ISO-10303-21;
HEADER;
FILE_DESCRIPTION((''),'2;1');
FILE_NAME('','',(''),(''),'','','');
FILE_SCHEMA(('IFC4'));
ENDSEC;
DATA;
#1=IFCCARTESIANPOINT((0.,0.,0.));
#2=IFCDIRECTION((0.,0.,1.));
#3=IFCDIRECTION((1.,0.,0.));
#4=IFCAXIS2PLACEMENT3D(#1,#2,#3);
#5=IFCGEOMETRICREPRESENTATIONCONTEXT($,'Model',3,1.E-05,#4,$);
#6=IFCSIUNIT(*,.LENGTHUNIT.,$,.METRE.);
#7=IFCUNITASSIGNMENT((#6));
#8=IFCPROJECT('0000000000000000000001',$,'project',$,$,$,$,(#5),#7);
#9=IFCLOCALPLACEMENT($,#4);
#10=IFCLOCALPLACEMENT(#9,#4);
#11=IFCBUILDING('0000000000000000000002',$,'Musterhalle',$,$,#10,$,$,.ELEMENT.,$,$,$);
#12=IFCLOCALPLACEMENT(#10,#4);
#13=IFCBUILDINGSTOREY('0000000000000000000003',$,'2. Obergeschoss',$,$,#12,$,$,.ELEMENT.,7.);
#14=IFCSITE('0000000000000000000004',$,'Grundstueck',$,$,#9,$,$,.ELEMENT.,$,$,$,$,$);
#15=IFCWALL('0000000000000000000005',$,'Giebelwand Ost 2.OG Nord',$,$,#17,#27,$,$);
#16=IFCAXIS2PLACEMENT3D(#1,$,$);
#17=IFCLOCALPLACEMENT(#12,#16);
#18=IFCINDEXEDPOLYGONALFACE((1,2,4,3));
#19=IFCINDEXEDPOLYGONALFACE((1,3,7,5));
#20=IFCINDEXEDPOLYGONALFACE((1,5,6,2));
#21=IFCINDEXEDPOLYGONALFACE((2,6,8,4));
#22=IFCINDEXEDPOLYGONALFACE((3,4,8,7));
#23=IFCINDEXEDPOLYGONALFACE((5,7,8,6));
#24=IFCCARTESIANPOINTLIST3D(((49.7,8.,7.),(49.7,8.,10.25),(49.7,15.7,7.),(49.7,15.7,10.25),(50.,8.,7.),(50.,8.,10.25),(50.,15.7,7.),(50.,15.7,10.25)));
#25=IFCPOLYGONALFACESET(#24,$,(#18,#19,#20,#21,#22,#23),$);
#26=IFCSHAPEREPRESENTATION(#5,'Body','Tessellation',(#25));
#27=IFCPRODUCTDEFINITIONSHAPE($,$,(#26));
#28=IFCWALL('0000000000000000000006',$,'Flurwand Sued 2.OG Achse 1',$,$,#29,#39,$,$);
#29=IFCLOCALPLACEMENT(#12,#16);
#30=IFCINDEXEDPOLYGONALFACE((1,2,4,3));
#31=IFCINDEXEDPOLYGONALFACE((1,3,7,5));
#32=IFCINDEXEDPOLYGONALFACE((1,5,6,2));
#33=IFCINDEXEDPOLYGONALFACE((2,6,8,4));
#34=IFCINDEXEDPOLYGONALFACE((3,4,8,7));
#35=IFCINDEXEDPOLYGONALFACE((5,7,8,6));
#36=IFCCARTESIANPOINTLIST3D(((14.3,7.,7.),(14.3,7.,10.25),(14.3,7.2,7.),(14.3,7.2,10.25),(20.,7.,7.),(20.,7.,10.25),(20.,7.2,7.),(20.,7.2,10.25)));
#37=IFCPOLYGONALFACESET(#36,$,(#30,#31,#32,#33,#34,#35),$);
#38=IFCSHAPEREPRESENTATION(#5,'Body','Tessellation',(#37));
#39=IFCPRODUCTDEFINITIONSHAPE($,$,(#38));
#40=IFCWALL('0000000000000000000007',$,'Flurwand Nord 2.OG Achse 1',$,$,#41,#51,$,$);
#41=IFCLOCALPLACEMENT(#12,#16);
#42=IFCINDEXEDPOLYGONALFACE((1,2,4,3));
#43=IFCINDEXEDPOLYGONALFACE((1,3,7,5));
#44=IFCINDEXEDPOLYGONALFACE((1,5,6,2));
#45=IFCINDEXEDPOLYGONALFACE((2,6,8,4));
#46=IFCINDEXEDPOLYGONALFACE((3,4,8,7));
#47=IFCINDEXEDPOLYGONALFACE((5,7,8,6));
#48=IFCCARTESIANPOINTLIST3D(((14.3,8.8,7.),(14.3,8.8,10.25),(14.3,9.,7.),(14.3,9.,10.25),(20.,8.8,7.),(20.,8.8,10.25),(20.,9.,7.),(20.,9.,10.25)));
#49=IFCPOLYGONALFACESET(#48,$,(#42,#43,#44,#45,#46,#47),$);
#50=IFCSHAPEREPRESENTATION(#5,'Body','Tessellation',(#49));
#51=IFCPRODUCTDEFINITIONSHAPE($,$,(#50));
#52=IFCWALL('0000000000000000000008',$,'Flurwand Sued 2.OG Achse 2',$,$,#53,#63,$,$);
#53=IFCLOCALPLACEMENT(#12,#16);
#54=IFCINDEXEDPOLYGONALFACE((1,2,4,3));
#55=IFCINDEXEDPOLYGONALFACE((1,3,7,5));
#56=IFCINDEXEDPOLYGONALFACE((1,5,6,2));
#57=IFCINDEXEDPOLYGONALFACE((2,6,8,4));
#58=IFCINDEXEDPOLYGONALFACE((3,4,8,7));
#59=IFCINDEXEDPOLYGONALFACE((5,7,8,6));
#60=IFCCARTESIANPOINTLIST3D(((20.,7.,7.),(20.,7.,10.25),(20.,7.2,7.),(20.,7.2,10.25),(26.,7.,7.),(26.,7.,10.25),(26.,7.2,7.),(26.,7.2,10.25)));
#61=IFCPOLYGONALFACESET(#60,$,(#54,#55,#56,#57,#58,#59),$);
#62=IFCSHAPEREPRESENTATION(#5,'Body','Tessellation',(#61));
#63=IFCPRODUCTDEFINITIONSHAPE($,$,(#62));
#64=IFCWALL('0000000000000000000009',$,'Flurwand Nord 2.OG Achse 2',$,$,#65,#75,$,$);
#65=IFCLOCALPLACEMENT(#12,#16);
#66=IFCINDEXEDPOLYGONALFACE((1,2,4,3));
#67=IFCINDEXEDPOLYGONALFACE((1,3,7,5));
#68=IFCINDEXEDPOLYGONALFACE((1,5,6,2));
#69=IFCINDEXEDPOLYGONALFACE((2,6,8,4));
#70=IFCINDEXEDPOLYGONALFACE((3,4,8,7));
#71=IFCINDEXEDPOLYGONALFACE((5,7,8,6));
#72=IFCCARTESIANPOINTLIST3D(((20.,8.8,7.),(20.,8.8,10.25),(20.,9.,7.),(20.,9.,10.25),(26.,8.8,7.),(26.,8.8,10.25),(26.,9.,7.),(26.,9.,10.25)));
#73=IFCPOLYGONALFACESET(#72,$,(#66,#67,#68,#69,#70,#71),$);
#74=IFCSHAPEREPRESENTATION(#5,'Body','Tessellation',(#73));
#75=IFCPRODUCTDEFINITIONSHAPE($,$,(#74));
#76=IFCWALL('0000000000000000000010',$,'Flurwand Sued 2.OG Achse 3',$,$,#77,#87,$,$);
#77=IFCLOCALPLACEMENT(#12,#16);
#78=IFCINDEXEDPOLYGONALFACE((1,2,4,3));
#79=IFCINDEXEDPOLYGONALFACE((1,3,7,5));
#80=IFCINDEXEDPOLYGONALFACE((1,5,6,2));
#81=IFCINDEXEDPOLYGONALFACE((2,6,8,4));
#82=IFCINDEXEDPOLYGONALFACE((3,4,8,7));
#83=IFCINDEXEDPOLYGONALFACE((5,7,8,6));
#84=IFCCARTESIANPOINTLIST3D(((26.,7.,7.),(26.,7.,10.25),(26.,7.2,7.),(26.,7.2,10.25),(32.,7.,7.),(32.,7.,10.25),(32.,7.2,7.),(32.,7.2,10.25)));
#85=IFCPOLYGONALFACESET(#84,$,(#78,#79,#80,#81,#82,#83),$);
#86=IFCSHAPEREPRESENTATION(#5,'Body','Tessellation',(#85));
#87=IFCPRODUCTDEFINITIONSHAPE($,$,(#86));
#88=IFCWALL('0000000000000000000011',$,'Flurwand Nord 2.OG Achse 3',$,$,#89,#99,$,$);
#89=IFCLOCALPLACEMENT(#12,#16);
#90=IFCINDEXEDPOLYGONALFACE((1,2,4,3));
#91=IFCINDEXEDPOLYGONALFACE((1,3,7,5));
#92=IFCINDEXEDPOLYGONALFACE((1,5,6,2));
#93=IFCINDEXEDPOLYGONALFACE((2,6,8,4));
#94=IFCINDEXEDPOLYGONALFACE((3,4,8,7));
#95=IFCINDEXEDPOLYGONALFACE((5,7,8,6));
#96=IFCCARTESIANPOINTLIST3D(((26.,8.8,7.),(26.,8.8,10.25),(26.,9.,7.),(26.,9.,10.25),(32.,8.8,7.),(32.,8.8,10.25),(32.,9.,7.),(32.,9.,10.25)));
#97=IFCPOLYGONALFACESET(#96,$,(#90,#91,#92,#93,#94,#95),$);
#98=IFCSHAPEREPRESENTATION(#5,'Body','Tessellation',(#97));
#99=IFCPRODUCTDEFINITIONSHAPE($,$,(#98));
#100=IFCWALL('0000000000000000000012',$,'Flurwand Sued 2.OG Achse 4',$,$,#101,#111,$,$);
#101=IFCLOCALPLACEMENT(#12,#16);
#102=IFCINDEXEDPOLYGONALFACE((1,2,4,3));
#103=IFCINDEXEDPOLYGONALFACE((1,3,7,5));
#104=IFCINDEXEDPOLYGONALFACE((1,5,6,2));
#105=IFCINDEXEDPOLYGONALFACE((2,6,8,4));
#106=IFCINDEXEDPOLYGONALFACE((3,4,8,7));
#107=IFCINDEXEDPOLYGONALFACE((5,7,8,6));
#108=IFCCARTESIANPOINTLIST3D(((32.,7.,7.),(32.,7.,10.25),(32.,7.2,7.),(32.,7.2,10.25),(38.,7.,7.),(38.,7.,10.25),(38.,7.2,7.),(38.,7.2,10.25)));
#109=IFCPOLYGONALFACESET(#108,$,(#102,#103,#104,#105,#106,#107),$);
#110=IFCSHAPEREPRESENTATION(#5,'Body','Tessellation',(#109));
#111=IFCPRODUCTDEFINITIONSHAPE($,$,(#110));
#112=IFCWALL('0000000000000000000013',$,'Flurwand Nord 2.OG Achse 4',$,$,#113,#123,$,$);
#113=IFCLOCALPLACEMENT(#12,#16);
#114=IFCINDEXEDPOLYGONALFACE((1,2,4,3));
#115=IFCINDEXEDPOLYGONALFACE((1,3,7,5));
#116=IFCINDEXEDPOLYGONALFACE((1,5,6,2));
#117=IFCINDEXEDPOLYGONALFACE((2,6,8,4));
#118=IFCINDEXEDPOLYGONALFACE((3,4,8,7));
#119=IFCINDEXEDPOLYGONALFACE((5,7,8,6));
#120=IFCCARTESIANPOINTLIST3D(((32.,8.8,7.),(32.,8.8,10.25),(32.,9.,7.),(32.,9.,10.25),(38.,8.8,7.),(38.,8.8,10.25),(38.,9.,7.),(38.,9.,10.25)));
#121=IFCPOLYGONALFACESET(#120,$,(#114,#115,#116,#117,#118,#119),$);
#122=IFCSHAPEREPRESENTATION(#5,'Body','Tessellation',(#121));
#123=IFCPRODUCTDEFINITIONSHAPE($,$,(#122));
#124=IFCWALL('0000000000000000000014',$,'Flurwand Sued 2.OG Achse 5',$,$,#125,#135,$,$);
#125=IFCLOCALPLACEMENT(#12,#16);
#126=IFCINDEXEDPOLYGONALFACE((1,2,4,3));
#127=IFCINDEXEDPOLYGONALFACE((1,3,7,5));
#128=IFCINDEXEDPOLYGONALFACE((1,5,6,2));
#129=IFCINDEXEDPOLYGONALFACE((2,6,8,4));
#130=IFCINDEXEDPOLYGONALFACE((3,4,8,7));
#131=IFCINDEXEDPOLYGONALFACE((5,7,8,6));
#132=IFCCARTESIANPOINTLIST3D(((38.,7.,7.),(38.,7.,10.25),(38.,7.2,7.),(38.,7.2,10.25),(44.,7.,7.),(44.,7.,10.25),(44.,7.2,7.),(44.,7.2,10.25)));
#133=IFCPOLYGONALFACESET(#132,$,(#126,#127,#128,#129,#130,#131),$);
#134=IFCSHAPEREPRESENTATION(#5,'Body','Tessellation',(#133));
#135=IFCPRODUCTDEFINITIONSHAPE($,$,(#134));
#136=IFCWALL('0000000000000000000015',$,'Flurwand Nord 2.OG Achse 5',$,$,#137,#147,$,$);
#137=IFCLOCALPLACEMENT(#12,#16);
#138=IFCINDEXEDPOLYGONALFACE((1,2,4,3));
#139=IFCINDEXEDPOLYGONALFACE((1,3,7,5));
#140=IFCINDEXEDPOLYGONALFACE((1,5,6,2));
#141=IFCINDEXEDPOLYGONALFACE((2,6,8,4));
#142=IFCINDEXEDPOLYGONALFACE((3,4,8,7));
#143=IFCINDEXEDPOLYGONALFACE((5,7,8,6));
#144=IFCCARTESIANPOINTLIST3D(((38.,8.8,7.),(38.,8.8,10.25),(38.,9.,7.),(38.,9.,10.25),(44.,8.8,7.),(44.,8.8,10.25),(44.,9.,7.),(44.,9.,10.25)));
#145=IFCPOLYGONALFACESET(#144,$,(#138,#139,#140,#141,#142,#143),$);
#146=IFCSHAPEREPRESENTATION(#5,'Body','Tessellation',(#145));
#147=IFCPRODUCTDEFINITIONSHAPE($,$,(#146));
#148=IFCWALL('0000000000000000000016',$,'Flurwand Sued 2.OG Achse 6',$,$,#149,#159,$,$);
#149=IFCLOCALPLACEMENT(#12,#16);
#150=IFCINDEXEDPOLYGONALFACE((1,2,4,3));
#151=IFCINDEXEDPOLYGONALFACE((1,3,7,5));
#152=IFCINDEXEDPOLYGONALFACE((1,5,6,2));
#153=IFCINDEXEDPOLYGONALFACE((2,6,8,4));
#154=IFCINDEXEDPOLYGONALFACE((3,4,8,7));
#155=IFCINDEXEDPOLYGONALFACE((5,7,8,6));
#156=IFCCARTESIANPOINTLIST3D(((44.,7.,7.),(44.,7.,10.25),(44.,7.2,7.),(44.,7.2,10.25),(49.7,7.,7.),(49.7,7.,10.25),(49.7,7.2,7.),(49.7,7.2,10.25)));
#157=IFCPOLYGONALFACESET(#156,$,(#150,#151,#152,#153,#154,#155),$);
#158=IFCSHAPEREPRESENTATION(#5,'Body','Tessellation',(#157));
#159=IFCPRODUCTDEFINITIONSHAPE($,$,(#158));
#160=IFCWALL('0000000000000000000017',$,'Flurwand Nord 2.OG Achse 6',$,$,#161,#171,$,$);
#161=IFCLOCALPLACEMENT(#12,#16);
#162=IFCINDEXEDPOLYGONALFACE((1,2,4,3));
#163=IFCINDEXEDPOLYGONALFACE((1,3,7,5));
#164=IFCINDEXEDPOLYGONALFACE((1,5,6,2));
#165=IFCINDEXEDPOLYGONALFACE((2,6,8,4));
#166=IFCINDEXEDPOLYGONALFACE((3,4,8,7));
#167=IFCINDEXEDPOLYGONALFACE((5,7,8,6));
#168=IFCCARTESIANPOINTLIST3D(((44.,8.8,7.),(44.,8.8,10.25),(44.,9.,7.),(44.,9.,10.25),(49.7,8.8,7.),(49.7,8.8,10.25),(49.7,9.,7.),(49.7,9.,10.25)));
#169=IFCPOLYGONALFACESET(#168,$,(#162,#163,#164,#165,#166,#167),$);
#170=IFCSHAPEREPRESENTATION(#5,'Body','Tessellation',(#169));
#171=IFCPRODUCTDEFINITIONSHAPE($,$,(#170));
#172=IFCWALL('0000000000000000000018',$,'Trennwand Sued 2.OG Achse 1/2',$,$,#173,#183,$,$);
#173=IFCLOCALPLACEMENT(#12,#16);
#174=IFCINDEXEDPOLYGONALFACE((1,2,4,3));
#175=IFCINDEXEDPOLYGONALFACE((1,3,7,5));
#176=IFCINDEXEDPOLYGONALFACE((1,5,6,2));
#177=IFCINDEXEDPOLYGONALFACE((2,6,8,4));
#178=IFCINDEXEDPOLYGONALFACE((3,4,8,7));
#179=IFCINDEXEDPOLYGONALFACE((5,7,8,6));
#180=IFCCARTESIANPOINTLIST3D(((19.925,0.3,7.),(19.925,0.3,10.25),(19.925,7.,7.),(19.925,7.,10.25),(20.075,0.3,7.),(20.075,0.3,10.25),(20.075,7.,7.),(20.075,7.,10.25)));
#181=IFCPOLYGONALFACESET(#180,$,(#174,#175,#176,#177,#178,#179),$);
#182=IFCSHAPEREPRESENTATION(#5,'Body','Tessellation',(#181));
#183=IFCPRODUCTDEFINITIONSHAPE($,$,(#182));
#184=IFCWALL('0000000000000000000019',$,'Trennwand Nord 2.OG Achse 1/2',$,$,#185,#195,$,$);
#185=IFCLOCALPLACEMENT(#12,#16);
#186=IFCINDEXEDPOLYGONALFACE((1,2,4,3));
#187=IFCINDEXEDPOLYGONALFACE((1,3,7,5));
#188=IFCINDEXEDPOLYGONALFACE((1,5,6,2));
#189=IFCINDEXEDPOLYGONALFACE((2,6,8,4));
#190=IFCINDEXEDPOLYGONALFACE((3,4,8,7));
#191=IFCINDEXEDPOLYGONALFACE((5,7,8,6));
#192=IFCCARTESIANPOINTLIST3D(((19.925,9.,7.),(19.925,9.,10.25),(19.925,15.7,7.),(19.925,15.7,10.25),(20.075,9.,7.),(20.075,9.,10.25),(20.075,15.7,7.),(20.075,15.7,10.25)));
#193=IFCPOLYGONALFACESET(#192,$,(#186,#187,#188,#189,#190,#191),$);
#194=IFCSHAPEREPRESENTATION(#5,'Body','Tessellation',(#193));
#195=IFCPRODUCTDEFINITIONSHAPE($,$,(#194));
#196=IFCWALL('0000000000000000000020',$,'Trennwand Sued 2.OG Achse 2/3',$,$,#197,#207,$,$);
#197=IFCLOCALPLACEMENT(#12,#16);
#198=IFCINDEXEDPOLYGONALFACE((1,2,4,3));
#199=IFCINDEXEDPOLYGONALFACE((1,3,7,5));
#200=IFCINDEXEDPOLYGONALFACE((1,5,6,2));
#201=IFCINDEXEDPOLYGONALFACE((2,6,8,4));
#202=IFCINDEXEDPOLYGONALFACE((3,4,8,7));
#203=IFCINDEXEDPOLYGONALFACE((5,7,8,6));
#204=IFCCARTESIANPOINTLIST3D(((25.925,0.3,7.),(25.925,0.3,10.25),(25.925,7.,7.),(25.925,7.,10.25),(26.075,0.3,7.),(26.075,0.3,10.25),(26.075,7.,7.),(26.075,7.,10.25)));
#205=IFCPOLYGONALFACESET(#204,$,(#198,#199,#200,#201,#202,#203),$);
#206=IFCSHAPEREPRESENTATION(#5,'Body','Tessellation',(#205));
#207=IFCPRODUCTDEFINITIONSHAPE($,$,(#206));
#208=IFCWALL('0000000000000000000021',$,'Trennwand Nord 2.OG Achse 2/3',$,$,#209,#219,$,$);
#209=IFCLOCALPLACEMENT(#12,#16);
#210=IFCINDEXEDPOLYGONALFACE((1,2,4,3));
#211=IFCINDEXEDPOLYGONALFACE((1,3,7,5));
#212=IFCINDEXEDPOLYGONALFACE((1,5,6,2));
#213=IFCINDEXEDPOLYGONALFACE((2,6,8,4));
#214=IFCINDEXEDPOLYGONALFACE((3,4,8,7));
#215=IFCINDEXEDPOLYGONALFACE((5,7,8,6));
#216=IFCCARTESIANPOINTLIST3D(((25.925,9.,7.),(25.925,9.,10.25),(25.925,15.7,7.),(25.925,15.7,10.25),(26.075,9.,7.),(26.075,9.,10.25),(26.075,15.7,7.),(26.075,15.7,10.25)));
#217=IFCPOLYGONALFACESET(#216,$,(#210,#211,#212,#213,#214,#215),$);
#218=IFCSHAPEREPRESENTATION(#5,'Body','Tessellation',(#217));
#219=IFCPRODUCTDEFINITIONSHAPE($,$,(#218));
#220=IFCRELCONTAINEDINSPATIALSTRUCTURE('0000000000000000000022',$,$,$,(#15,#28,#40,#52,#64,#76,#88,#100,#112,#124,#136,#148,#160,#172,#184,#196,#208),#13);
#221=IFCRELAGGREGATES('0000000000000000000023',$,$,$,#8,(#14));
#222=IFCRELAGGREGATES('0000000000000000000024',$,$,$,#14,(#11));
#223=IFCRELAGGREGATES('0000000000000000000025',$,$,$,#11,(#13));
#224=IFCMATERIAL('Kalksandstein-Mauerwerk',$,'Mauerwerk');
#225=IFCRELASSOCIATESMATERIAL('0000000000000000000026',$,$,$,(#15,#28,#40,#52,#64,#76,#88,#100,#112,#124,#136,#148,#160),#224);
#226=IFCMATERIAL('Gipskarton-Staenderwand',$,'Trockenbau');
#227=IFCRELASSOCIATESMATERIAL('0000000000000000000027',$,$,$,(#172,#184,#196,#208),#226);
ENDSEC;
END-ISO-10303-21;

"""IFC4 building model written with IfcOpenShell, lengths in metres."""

from ifc_helpers import new_model, si_unit, frame, origin_with_axes, origin_2d, place, context, project, spatial, rectangle, extrude, material, element, save


model = new_model("IFC4")

# Units and contexts
model_context = context("Model", 3, precision=1e-05, world=origin_with_axes())
ifc_project = project(units=[si_unit("LENGTHUNIT", "METRE")], contexts=[model_context])

# Site, building, storey
site_placement = place(None, origin_with_axes())
site = spatial("IfcSite", under=ifc_project, at=site_placement, Name="Grundstueck", CompositionType="ELEMENT")
building_placement = place(site_placement, origin_with_axes())
building = spatial("IfcBuilding", under=site, at=building_placement, Name="Musterhalle", CompositionType="ELEMENT")
storey_placement = place(building_placement, origin_with_axes())
storey = spatial("IfcBuildingStorey", under=building, at=storey_placement, Name="2. Obergeschoss", CompositionType="ELEMENT", Elevation=7.0)

# Walls
ifc_material_1 = material(Name="Kalksandstein-Mauerwerk", Category="Mauerwerk")
placement = place(storey_placement, origin_with_axes())
element("IfcWall", 1, at=placement, inside=storey, material=ifc_material_1, Name="Giebelwand Ost 2.OG Nord", context=model_context, shape_type="SweptSolid", body=[
    extrude(rectangle(XDim=0.3, YDim=7.7, at=origin_2d()), frame((49.85, 11.85, 7.0), z_axis=(0.0, 0.0, 1.0), x_axis=(1.0, 0.0, 0.0)), (0.0, 0.0, 1.0), 3.25),
])
element("IfcWall", 2, at=placement, inside=storey, material=ifc_material_1, Name="Flurwand Sued 2.OG Achse 1", context=model_context, shape_type="SweptSolid", body=[
    extrude(rectangle(XDim=5.7, YDim=0.2, at=origin_2d()), frame((17.15, 7.1, 7.0), z_axis=(0.0, 0.0, 1.0), x_axis=(1.0, 0.0, 0.0)), (0.0, 0.0, 1.0), 3.25),
])
element("IfcWall", 3, at=placement, inside=storey, material=ifc_material_1, Name="Flurwand Nord 2.OG Achse 1", context=model_context, shape_type="SweptSolid", body=[
    extrude(rectangle(XDim=5.7, YDim=0.2, at=origin_2d()), frame((17.15, 8.9, 7.0), z_axis=(0.0, 0.0, 1.0), x_axis=(1.0, 0.0, 0.0)), (0.0, 0.0, 1.0), 3.25),
])
element("IfcWall", 4, at=placement, inside=storey, material=ifc_material_1, Name="Flurwand Sued 2.OG Achse 2", context=model_context, shape_type="SweptSolid", body=[
    extrude(rectangle(XDim=6.0, YDim=0.2, at=origin_2d()), frame((23.0, 7.1, 7.0), z_axis=(0.0, 0.0, 1.0), x_axis=(1.0, 0.0, 0.0)), (0.0, 0.0, 1.0), 3.25),
])
element("IfcWall", 5, at=placement, inside=storey, material=ifc_material_1, Name="Flurwand Nord 2.OG Achse 2", context=model_context, shape_type="SweptSolid", body=[
    extrude(rectangle(XDim=6.0, YDim=0.2, at=origin_2d()), frame((23.0, 8.9, 7.0), z_axis=(0.0, 0.0, 1.0), x_axis=(1.0, 0.0, 0.0)), (0.0, 0.0, 1.0), 3.25),
])
element("IfcWall", 6, at=placement, inside=storey, material=ifc_material_1, Name="Flurwand Sued 2.OG Achse 3", context=model_context, shape_type="SweptSolid", body=[
    extrude(rectangle(XDim=6.0, YDim=0.2, at=origin_2d()), frame((29.0, 7.1, 7.0), z_axis=(0.0, 0.0, 1.0), x_axis=(1.0, 0.0, 0.0)), (0.0, 0.0, 1.0), 3.25),
])
element("IfcWall", 7, at=placement, inside=storey, material=ifc_material_1, Name="Flurwand Nord 2.OG Achse 3", context=model_context, shape_type="SweptSolid", body=[
    extrude(rectangle(XDim=6.0, YDim=0.2, at=origin_2d()), frame((29.0, 8.9, 7.0), z_axis=(0.0, 0.0, 1.0), x_axis=(1.0, 0.0, 0.0)), (0.0, 0.0, 1.0), 3.25),
])
element("IfcWall", 8, at=placement, inside=storey, material=ifc_material_1, Name="Flurwand Sued 2.OG Achse 4", context=model_context, shape_type="SweptSolid", body=[
    extrude(rectangle(XDim=6.0, YDim=0.2, at=origin_2d()), frame((35.0, 7.1, 7.0), z_axis=(0.0, 0.0, 1.0), x_axis=(1.0, 0.0, 0.0)), (0.0, 0.0, 1.0), 3.25),
])
element("IfcWall", 9, at=placement, inside=storey, material=ifc_material_1, Name="Flurwand Nord 2.OG Achse 4", context=model_context, shape_type="SweptSolid", body=[
    extrude(rectangle(XDim=6.0, YDim=0.2, at=origin_2d()), frame((35.0, 8.9, 7.0), z_axis=(0.0, 0.0, 1.0), x_axis=(1.0, 0.0, 0.0)), (0.0, 0.0, 1.0), 3.25),
])
element("IfcWall", 10, at=placement, inside=storey, material=ifc_material_1, Name="Flurwand Sued 2.OG Achse 5", context=model_context, shape_type="SweptSolid", body=[
    extrude(rectangle(XDim=6.0, YDim=0.2, at=origin_2d()), frame((41.0, 7.1, 7.0), z_axis=(0.0, 0.0, 1.0), x_axis=(1.0, 0.0, 0.0)), (0.0, 0.0, 1.0), 3.25),
])
element("IfcWall", 11, at=placement, inside=storey, material=ifc_material_1, Name="Flurwand Nord 2.OG Achse 5", context=model_context, shape_type="SweptSolid", body=[
    extrude(rectangle(XDim=6.0, YDim=0.2, at=origin_2d()), frame((41.0, 8.9, 7.0), z_axis=(0.0, 0.0, 1.0), x_axis=(1.0, 0.0, 0.0)), (0.0, 0.0, 1.0), 3.25),
])
element("IfcWall", 12, at=placement, inside=storey, material=ifc_material_1, Name="Flurwand Sued 2.OG Achse 6", context=model_context, shape_type="SweptSolid", body=[
    extrude(rectangle(XDim=5.7, YDim=0.2, at=origin_2d()), frame((46.85, 7.1, 7.0), z_axis=(0.0, 0.0, 1.0), x_axis=(1.0, 0.0, 0.0)), (0.0, 0.0, 1.0), 3.25),
])
element("IfcWall", 13, at=placement, inside=storey, material=ifc_material_1, Name="Flurwand Nord 2.OG Achse 6", context=model_context, shape_type="SweptSolid", body=[
    extrude(rectangle(XDim=5.7, YDim=0.2, at=origin_2d()), frame((46.85, 8.9, 7.0), z_axis=(0.0, 0.0, 1.0), x_axis=(1.0, 0.0, 0.0)), (0.0, 0.0, 1.0), 3.25),
])
ifc_material_2 = material(Name="Gipskarton-Staenderwand", Category="Trockenbau")
element("IfcWall", 14, at=placement, inside=storey, material=ifc_material_2, Name="Trennwand Sued 2.OG Achse 1/2", context=model_context, shape_type="SweptSolid", body=[
    extrude(rectangle(XDim=0.15, YDim=6.7, at=origin_2d()), frame((20.0, 3.65, 7.0), z_axis=(0.0, 0.0, 1.0), x_axis=(1.0, 0.0, 0.0)), (0.0, 0.0, 1.0), 3.25),
])
element("IfcWall", 15, at=placement, inside=storey, material=ifc_material_2, Name="Trennwand Nord 2.OG Achse 1/2", context=model_context, shape_type="SweptSolid", body=[
    extrude(rectangle(XDim=0.15, YDim=6.7, at=origin_2d()), frame((20.0, 12.35, 7.0), z_axis=(0.0, 0.0, 1.0), x_axis=(1.0, 0.0, 0.0)), (0.0, 0.0, 1.0), 3.25),
])
element("IfcWall", 16, at=placement, inside=storey, material=ifc_material_2, Name="Trennwand Sued 2.OG Achse 2/3", context=model_context, shape_type="SweptSolid", body=[
    extrude(rectangle(XDim=0.15, YDim=6.7, at=origin_2d()), frame((26.0, 3.65, 7.0), z_axis=(0.0, 0.0, 1.0), x_axis=(1.0, 0.0, 0.0)), (0.0, 0.0, 1.0), 3.25),
])
element("IfcWall", 17, at=placement, inside=storey, material=ifc_material_2, Name="Trennwand Nord 2.OG Achse 2/3", context=model_context, shape_type="SweptSolid", body=[
    extrude(rectangle(XDim=0.15, YDim=6.7, at=origin_2d()), frame((26.0, 12.35, 7.0), z_axis=(0.0, 0.0, 1.0), x_axis=(1.0, 0.0, 0.0)), (0.0, 0.0, 1.0), 3.25),
])

save(model, "model.ifc")
